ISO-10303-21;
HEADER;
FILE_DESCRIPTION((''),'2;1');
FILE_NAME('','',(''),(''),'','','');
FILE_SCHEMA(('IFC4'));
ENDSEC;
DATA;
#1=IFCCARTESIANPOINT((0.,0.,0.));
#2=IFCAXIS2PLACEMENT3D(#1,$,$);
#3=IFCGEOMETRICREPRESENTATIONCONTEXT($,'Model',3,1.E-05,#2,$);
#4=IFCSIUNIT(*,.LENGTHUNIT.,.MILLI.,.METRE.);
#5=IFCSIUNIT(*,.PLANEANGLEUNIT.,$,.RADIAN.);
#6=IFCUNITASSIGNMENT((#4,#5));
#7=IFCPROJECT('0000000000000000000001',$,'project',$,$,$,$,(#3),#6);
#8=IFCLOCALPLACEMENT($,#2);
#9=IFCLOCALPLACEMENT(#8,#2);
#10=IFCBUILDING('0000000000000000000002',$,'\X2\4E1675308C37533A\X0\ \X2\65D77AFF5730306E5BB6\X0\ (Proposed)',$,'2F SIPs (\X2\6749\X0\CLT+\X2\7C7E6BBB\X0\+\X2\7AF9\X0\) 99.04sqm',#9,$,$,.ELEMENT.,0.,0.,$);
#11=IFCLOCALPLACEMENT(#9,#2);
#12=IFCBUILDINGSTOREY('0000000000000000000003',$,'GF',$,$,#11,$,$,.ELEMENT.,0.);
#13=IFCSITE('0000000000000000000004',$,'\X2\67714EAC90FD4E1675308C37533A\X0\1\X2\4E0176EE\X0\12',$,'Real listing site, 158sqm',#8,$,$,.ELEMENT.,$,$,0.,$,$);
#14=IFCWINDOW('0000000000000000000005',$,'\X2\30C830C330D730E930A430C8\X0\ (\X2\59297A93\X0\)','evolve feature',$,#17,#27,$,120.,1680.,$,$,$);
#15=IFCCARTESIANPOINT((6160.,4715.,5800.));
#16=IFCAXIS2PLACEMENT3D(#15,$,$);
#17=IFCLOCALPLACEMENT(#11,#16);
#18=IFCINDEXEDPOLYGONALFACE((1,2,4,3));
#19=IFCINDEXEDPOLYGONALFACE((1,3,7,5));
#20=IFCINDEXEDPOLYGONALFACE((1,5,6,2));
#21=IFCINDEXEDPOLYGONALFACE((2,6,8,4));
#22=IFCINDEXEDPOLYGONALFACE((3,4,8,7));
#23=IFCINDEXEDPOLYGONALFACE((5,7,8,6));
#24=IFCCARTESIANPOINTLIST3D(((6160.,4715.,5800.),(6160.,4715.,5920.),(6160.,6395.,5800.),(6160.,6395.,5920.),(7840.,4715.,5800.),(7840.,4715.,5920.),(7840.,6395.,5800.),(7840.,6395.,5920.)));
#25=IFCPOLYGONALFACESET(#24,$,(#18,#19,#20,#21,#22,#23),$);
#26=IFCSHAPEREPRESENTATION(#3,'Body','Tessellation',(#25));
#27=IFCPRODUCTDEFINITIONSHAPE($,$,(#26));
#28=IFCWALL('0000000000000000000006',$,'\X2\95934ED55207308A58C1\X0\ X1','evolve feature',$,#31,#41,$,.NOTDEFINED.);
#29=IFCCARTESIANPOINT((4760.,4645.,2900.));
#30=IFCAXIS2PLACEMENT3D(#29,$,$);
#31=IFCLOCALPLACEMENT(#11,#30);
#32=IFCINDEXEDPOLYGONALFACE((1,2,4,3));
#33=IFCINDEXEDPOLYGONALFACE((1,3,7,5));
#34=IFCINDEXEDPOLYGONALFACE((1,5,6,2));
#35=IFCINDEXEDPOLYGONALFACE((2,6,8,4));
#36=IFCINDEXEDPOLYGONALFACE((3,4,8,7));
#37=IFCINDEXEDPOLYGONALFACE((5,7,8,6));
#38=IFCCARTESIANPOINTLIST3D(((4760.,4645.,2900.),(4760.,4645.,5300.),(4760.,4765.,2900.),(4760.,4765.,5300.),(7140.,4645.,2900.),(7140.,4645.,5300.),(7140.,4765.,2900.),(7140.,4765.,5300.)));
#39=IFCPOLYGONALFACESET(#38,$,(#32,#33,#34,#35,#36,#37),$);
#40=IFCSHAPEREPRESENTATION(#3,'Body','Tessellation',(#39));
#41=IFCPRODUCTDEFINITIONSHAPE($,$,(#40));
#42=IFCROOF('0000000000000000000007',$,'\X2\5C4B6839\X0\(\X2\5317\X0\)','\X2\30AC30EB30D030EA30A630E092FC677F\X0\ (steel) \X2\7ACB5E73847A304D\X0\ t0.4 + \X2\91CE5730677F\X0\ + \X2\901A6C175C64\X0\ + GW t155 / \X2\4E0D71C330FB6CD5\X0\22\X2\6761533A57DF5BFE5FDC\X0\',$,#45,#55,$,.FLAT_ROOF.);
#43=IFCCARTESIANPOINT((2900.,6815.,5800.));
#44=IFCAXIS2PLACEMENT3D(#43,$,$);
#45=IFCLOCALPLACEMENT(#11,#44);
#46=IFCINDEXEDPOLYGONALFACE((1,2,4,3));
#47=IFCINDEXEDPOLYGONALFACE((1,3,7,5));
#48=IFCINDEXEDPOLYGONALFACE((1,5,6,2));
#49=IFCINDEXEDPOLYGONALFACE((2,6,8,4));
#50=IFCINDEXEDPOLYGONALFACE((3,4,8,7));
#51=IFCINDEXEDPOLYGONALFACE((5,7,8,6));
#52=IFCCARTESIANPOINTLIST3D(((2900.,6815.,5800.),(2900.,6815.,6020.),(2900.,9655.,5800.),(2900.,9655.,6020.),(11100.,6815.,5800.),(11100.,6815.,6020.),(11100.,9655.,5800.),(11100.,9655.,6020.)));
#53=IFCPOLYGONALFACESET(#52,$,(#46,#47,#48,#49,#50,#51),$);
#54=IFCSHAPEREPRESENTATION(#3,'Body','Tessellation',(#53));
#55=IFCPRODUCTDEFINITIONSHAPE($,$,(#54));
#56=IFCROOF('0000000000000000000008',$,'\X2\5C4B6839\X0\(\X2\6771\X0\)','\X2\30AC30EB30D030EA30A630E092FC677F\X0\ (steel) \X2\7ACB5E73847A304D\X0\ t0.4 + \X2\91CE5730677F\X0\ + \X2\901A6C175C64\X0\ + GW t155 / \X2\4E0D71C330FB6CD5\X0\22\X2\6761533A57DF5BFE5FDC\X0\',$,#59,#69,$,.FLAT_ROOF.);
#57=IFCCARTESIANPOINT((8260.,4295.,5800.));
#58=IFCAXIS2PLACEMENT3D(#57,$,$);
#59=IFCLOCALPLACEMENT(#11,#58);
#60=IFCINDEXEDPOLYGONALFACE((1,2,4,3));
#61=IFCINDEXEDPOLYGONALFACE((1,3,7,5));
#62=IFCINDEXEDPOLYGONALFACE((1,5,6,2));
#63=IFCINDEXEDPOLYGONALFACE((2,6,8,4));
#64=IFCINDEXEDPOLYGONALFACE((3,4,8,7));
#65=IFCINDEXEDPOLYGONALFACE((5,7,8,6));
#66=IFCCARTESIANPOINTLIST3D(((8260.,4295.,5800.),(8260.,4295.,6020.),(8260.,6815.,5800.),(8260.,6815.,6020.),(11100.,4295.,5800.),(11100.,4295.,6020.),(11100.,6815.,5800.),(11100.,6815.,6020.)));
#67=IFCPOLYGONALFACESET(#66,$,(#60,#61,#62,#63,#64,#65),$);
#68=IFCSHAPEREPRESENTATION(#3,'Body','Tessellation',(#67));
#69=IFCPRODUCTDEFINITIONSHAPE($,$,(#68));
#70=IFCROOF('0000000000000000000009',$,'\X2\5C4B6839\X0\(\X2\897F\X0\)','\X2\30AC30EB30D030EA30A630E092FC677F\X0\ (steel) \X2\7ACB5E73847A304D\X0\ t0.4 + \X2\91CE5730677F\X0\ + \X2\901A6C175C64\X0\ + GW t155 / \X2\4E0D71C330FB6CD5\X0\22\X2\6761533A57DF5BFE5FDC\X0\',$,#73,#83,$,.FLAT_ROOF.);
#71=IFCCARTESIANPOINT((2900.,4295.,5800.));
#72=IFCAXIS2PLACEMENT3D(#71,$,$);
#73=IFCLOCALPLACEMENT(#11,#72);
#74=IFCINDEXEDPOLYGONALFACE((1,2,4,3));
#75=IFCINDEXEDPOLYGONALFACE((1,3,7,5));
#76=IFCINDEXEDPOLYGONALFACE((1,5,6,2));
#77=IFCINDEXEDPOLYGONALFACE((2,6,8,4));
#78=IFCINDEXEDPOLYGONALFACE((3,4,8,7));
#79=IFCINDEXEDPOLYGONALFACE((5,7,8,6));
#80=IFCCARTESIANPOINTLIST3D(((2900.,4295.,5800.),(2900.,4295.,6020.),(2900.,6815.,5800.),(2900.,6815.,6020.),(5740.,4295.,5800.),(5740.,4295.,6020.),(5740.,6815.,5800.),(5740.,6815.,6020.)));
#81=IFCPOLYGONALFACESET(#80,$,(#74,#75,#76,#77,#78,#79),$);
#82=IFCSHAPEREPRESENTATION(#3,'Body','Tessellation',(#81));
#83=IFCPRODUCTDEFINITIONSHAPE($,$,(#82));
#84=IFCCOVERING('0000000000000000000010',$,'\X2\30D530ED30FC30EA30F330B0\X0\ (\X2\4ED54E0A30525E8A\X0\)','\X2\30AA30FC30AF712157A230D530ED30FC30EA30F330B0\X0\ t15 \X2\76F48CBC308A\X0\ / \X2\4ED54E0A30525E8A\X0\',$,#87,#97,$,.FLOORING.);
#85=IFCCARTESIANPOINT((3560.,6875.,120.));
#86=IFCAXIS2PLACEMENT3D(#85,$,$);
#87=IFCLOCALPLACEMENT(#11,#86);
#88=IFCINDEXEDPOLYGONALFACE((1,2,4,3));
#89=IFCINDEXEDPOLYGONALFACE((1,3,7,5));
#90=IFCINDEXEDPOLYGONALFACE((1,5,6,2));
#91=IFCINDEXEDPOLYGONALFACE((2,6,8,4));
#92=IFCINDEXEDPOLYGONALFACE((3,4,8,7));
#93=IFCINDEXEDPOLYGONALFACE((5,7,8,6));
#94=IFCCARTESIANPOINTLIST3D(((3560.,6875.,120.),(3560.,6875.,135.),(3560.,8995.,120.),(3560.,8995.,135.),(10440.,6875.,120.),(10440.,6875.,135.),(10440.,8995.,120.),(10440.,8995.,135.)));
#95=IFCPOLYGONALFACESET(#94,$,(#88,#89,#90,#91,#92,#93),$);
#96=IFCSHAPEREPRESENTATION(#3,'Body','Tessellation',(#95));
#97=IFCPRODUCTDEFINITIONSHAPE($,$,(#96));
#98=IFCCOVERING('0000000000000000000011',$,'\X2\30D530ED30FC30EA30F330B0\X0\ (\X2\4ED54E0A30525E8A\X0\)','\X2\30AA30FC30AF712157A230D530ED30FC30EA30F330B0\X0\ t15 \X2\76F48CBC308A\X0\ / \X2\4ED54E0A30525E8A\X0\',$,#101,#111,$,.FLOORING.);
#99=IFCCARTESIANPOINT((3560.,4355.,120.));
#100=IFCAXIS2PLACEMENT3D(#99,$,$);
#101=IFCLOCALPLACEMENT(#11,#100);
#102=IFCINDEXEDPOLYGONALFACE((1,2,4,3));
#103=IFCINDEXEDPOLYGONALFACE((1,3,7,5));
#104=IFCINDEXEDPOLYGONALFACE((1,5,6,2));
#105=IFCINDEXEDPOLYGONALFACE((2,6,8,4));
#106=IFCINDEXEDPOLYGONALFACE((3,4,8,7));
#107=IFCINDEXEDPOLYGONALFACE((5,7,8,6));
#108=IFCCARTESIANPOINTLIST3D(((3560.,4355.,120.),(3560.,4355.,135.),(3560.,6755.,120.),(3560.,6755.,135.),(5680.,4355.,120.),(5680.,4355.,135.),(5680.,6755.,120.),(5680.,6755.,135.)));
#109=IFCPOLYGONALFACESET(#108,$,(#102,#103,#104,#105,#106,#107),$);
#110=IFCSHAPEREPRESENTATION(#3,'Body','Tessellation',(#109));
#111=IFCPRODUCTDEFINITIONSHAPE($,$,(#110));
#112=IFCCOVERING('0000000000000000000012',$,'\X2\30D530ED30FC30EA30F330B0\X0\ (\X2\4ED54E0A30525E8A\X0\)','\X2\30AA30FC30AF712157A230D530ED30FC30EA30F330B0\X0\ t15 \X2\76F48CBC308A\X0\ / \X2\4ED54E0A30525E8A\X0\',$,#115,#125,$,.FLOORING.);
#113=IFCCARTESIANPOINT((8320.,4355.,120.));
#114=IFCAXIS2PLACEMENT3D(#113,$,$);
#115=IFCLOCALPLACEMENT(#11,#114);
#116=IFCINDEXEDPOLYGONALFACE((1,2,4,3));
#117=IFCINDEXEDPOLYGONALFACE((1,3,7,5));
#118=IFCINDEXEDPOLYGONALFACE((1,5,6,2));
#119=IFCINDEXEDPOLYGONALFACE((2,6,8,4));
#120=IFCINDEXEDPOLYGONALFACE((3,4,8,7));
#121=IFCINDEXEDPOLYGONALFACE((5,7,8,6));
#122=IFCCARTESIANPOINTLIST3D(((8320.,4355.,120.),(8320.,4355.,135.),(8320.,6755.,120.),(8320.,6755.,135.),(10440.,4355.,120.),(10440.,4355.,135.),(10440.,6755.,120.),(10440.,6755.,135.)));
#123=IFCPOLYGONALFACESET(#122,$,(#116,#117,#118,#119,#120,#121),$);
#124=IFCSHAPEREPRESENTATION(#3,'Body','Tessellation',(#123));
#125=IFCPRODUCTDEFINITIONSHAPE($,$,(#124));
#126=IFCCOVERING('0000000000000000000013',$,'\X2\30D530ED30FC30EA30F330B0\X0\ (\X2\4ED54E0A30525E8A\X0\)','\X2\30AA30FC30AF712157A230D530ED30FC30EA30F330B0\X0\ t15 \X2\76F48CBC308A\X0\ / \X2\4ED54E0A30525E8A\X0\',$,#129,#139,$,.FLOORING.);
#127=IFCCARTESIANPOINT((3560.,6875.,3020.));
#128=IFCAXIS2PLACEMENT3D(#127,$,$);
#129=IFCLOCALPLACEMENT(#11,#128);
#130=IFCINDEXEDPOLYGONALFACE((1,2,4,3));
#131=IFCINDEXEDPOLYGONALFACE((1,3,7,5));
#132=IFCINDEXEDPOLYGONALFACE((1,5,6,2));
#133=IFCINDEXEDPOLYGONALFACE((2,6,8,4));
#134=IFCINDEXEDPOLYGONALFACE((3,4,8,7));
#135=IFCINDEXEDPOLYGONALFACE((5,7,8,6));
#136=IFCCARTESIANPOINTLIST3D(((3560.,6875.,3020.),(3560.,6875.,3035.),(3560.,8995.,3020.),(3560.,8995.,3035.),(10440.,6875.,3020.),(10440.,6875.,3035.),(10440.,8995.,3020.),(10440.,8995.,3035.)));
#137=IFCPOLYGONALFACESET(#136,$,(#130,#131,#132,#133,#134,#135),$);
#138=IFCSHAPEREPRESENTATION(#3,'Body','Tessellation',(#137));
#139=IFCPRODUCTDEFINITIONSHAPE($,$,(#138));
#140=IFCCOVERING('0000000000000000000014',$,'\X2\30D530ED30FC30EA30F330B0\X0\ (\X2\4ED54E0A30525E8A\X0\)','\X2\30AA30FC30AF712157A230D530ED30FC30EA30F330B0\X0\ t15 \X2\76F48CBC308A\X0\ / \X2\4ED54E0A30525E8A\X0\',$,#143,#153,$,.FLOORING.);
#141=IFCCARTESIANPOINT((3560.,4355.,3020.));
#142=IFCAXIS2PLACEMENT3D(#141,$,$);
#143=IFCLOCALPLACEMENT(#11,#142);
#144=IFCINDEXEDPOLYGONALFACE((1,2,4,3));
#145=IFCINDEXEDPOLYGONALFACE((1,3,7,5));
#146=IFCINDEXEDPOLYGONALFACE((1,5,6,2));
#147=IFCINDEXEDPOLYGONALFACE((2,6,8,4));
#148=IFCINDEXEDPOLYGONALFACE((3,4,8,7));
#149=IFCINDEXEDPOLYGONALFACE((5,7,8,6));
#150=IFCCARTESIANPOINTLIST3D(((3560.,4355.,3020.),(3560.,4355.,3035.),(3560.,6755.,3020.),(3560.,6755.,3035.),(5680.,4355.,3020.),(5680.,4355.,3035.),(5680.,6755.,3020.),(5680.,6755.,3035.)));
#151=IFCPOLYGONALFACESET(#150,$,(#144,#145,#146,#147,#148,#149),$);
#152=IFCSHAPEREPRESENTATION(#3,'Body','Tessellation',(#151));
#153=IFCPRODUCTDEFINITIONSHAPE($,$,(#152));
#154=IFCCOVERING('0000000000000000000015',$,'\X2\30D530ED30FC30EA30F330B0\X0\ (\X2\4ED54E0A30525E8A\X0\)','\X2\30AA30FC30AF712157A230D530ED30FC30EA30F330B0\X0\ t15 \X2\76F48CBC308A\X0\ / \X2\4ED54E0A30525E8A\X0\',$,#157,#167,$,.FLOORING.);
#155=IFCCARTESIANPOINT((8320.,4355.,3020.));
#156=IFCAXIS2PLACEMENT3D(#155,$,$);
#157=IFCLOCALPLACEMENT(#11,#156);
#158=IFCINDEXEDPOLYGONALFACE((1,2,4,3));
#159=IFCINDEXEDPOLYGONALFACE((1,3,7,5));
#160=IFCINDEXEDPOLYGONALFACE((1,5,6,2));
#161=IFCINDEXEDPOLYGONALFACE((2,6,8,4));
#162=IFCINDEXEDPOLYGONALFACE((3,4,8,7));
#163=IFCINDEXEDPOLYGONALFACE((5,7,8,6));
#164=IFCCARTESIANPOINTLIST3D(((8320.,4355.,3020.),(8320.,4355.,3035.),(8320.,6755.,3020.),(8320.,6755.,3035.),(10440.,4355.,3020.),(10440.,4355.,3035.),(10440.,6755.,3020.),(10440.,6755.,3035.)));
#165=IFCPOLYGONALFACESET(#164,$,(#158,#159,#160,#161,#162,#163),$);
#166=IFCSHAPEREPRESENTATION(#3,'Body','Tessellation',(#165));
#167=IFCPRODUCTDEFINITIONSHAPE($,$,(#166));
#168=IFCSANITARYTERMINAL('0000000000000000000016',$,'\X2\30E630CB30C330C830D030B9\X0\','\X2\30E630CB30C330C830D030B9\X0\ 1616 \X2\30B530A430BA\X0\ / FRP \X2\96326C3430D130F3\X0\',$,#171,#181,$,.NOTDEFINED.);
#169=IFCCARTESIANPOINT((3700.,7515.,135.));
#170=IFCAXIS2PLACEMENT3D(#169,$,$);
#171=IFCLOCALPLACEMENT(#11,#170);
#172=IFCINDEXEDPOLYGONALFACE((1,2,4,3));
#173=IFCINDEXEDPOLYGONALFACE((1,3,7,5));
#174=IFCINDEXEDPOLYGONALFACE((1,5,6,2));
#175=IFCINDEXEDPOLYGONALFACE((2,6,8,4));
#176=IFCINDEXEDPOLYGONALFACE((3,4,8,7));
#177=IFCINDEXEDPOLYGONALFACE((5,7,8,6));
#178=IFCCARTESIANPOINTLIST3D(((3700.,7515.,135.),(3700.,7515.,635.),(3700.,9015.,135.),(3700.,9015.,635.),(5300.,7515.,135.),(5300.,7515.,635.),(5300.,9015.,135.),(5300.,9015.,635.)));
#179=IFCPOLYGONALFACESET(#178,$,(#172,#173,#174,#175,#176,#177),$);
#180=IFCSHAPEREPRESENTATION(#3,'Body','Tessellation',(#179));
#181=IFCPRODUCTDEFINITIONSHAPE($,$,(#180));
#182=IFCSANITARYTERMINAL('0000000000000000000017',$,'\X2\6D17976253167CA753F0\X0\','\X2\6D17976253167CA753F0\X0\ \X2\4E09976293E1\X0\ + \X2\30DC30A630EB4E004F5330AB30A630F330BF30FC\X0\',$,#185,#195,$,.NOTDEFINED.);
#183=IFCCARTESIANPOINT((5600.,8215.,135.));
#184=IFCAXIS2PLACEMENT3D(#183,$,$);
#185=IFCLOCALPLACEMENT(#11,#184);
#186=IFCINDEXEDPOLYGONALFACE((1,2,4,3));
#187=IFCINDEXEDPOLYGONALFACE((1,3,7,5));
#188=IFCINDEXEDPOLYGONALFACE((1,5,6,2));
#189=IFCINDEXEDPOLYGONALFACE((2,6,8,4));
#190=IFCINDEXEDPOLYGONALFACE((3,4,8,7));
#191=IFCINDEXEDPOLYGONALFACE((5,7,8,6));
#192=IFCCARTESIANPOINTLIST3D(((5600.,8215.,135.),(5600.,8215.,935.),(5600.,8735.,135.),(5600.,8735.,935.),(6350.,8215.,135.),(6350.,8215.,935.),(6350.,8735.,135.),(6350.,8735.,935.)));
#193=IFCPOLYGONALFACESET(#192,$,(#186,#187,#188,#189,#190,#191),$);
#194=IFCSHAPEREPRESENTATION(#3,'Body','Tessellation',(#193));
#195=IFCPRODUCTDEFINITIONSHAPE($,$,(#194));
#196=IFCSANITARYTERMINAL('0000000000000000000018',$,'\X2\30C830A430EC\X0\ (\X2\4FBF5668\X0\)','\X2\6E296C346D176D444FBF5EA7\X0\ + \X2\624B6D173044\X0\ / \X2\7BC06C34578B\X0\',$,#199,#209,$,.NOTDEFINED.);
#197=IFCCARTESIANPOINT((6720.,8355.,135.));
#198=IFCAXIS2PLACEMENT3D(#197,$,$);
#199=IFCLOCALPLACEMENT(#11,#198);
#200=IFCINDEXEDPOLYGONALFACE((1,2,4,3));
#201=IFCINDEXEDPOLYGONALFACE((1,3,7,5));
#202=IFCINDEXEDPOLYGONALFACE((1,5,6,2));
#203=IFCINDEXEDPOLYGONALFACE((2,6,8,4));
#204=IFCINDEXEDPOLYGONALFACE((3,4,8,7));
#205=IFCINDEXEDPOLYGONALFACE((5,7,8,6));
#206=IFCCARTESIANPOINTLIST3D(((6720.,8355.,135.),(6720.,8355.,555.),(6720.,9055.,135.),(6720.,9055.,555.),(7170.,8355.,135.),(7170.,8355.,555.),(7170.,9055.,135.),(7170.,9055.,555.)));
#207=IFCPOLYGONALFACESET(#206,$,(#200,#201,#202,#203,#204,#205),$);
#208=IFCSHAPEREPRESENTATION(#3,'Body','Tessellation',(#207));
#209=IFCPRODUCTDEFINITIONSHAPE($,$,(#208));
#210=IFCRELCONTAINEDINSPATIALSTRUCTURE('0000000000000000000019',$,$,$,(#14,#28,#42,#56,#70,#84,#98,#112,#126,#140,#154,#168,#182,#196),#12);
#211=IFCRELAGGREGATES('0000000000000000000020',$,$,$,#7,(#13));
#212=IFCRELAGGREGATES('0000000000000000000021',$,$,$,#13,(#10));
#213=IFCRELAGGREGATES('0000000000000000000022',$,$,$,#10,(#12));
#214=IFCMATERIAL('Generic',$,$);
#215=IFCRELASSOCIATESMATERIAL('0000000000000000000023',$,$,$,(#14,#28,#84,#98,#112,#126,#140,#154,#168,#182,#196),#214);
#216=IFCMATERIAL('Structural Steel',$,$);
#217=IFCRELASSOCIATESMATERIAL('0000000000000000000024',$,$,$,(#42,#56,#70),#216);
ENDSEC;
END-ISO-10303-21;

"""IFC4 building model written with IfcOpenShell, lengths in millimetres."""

from ifc_helpers import new_model, si_unit, frame, frame_2d, origin, place, context, project, spatial, rectangle, extrude, material, element, save


model = new_model("IFC4")

# Units and contexts
model_context = context("Model", 3, precision=1e-05, world=origin())
ifc_project = project(units=[si_unit("LENGTHUNIT", "METRE", prefix="MILLI"), si_unit("PLANEANGLEUNIT", "RADIAN")], contexts=[model_context])

# Site, building, storey
site_placement = place(None, origin())
site = spatial("IfcSite", under=ifc_project, at=site_placement, Name="東京都世田谷区1丁目12", ObjectType="Real listing site, 158sqm", CompositionType="ELEMENT", RefElevation=0.0)
building_placement = place(site_placement, origin())
building = spatial("IfcBuilding", under=site, at=building_placement, Name="世田谷区 旗竿地の家 (Proposed)", ObjectType="2F SIPs (杉CLT+籾殻+竹) 99.04sqm", CompositionType="ELEMENT", ElevationOfRefHeight=0.0, ElevationOfTerrain=0.0)
storey_placement = place(building_placement, origin())
storey = spatial("IfcBuildingStorey", under=building, at=storey_placement, Name="GF", CompositionType="ELEMENT", Elevation=0.0)

# Window
ifc_material_1 = material(Name="Generic")
window_1_placement = place(storey_placement, frame((6160.0, 4715.0, 5800.0)))
element("IfcWindow", 1, at=window_1_placement, inside=storey, material=ifc_material_1, Name="トップライト (天窓)", Description="evolve feature", OverallHeight=120.0, OverallWidth=1680.0, context=model_context, shape_type="SweptSolid", body=[
    extrude(rectangle(XDim=1680.0, YDim=1680.0, at=frame_2d((840.0, 840.0))), frame((6160.0, 4715.0, 5800.0)), (0.0, 0.0, 1.0), 120.0),
])

# Wall
wall_1_placement = place(storey_placement, frame((4760.0, 4645.0, 2900.0)))
element("IfcWall", 2, at=wall_1_placement, inside=storey, material=ifc_material_1, Name="間仕切り壁 X1", Description="evolve feature", PredefinedType="NOTDEFINED", context=model_context, shape_type="SweptSolid", body=[
    extrude(rectangle(XDim=2380.0, YDim=120.0, at=frame_2d((1190.0, 60.0))), frame((4760.0, 4645.0, 2900.0)), (0.0, 0.0, 1.0), 2400.0),
])

# Roofs
ifc_material_2 = material(Name="Structural Steel")
roof_1_placement = place(storey_placement, frame((2900.0, 6815.0, 5800.0)))
element("IfcRoof", 3, at=roof_1_placement, inside=storey, material=ifc_material_2, Name="屋根(北)", Description="ガルバリウム鋼板 (steel) 立平葺き t0.4 + 野地板 + 通気層 + GW t155 / 不燃・法22条区域対応", PredefinedType="FLAT_ROOF", context=model_context, shape_type="SweptSolid", body=[
    extrude(rectangle(XDim=8200.0, YDim=2840.0, at=frame_2d((4100.0, 1420.0))), frame((2900.0, 6815.0, 5800.0)), (0.0, 0.0, 1.0), 220.0),
])
roof_2_placement = place(storey_placement, frame((8260.0, 4295.0, 5800.0)))
element("IfcRoof", 4, at=roof_2_placement, inside=storey, material=ifc_material_2, Name="屋根(東)", Description="ガルバリウム鋼板 (steel) 立平葺き t0.4 + 野地板 + 通気層 + GW t155 / 不燃・法22条区域対応", PredefinedType="FLAT_ROOF", context=model_context, shape_type="SweptSolid", body=[
    extrude(rectangle(XDim=2840.0, YDim=2520.0, at=frame_2d((1420.0, 1260.0))), frame((8260.0, 4295.0, 5800.0)), (0.0, 0.0, 1.0), 220.0),
])
roof_3_placement = place(storey_placement, frame((2900.0, 4295.0, 5800.0)))
element("IfcRoof", 5, at=roof_3_placement, inside=storey, material=ifc_material_2, Name="屋根(西)", Description="ガルバリウム鋼板 (steel) 立平葺き t0.4 + 野地板 + 通気層 + GW t155 / 不燃・法22条区域対応", PredefinedType="FLAT_ROOF", context=model_context, shape_type="SweptSolid", body=[
    extrude(rectangle(XDim=2840.0, YDim=2520.0, at=frame_2d((1420.0, 1260.0))), frame((2900.0, 4295.0, 5800.0)), (0.0, 0.0, 1.0), 220.0),
])

# Coverings
covering_1_placement = place(storey_placement, frame((3560.0, 6875.0, 120.0)))
element("IfcCovering", 6, at=covering_1_placement, inside=storey, material=ifc_material_1, Name="フローリング (仕上げ床)", Description="オーク無垢フローリング t15 直貼り / 仕上げ床", PredefinedType="FLOORING", context=model_context, shape_type="SweptSolid", body=[
    extrude(rectangle(XDim=6880.0, YDim=2120.0, at=frame_2d((3440.0, 1060.0))), frame((3560.0, 6875.0, 120.0)), (0.0, 0.0, 1.0), 15.0),
])
covering_2_placement = place(storey_placement, frame((3560.0, 4355.0, 120.0)))
element("IfcCovering", 7, at=covering_2_placement, inside=storey, material=ifc_material_1, Name="フローリング (仕上げ床)", Description="オーク無垢フローリング t15 直貼り / 仕上げ床", PredefinedType="FLOORING", context=model_context, shape_type="SweptSolid", body=[
    extrude(rectangle(XDim=2120.0, YDim=2400.0, at=frame_2d((1060.0, 1200.0))), frame((3560.0, 4355.0, 120.0)), (0.0, 0.0, 1.0), 15.0),
])
covering_3_placement = place(storey_placement, frame((8320.0, 4355.0, 120.0)))
element("IfcCovering", 8, at=covering_3_placement, inside=storey, material=ifc_material_1, Name="フローリング (仕上げ床)", Description="オーク無垢フローリング t15 直貼り / 仕上げ床", PredefinedType="FLOORING", context=model_context, shape_type="SweptSolid", body=[
    extrude(rectangle(XDim=2120.0, YDim=2400.0, at=frame_2d((1060.0, 1200.0))), frame((8320.0, 4355.0, 120.0)), (0.0, 0.0, 1.0), 15.0),
])
covering_4_placement = place(storey_placement, frame((3560.0, 6875.0, 3020.0)))
element("IfcCovering", 9, at=covering_4_placement, inside=storey, material=ifc_material_1, Name="フローリング (仕上げ床)", Description="オーク無垢フローリング t15 直貼り / 仕上げ床", PredefinedType="FLOORING", context=model_context, shape_type="SweptSolid", body=[
    extrude(rectangle(XDim=6880.0, YDim=2120.0, at=frame_2d((3440.0, 1060.0))), frame((3560.0, 6875.0, 3020.0)), (0.0, 0.0, 1.0), 15.0),
])
covering_5_placement = place(storey_placement, frame((3560.0, 4355.0, 3020.0)))
element("IfcCovering", 10, at=covering_5_placement, inside=storey, material=ifc_material_1, Name="フローリング (仕上げ床)", Description="オーク無垢フローリング t15 直貼り / 仕上げ床", PredefinedType="FLOORING", context=model_context, shape_type="SweptSolid", body=[
    extrude(rectangle(XDim=2120.0, YDim=2400.0, at=frame_2d((1060.0, 1200.0))), frame((3560.0, 4355.0, 3020.0)), (0.0, 0.0, 1.0), 15.0),
])
covering_6_placement = place(storey_placement, frame((8320.0, 4355.0, 3020.0)))
element("IfcCovering", 11, at=covering_6_placement, inside=storey, material=ifc_material_1, Name="フローリング (仕上げ床)", Description="オーク無垢フローリング t15 直貼り / 仕上げ床", PredefinedType="FLOORING", context=model_context, shape_type="SweptSolid", body=[
    extrude(rectangle(XDim=2120.0, YDim=2400.0, at=frame_2d((1060.0, 1200.0))), frame((8320.0, 4355.0, 3020.0)), (0.0, 0.0, 1.0), 15.0),
])

# Sanitary terminals
sanitary_terminal_1_placement = place(storey_placement, frame((3700.0, 7515.0, 135.0)))
element("IfcSanitaryTerminal", 12, at=sanitary_terminal_1_placement, inside=storey, material=ifc_material_1, Name="ユニットバス", Description="ユニットバス 1616 サイズ / FRP 防水パン", PredefinedType="NOTDEFINED", context=model_context, shape_type="SweptSolid", body=[
    extrude(rectangle(XDim=1600.0, YDim=1500.0, at=frame_2d((800.0, 750.0))), frame((3700.0, 7515.0, 135.0)), (0.0, 0.0, 1.0), 500.0),
])
sanitary_terminal_2_placement = place(storey_placement, frame((5600.0, 8215.0, 135.0)))
element("IfcSanitaryTerminal", 13, at=sanitary_terminal_2_placement, inside=storey, material=ifc_material_1, Name="洗面化粧台", Description="洗面化粧台 三面鏡 + ボウル一体カウンター", PredefinedType="NOTDEFINED", context=model_context, shape_type="SweptSolid", body=[
    extrude(rectangle(XDim=750.0, YDim=520.0, at=frame_2d((375.0, 260.0))), frame((5600.0, 8215.0, 135.0)), (0.0, 0.0, 1.0), 800.0),
])
sanitary_terminal_3_placement = place(storey_placement, frame((6720.0, 8355.0, 135.0)))
element("IfcSanitaryTerminal", 14, at=sanitary_terminal_3_placement, inside=storey, material=ifc_material_1, Name="トイレ (便器)", Description="温水洗浄便座 + 手洗い / 節水型", PredefinedType="NOTDEFINED", context=model_context, shape_type="SweptSolid", body=[
    extrude(rectangle(XDim=450.0, YDim=700.0, at=frame_2d((225.0, 350.0))), frame((6720.0, 8355.0, 135.0)), (0.0, 0.0, 1.0), 420.0),
])

save(model, "model.ifc")
